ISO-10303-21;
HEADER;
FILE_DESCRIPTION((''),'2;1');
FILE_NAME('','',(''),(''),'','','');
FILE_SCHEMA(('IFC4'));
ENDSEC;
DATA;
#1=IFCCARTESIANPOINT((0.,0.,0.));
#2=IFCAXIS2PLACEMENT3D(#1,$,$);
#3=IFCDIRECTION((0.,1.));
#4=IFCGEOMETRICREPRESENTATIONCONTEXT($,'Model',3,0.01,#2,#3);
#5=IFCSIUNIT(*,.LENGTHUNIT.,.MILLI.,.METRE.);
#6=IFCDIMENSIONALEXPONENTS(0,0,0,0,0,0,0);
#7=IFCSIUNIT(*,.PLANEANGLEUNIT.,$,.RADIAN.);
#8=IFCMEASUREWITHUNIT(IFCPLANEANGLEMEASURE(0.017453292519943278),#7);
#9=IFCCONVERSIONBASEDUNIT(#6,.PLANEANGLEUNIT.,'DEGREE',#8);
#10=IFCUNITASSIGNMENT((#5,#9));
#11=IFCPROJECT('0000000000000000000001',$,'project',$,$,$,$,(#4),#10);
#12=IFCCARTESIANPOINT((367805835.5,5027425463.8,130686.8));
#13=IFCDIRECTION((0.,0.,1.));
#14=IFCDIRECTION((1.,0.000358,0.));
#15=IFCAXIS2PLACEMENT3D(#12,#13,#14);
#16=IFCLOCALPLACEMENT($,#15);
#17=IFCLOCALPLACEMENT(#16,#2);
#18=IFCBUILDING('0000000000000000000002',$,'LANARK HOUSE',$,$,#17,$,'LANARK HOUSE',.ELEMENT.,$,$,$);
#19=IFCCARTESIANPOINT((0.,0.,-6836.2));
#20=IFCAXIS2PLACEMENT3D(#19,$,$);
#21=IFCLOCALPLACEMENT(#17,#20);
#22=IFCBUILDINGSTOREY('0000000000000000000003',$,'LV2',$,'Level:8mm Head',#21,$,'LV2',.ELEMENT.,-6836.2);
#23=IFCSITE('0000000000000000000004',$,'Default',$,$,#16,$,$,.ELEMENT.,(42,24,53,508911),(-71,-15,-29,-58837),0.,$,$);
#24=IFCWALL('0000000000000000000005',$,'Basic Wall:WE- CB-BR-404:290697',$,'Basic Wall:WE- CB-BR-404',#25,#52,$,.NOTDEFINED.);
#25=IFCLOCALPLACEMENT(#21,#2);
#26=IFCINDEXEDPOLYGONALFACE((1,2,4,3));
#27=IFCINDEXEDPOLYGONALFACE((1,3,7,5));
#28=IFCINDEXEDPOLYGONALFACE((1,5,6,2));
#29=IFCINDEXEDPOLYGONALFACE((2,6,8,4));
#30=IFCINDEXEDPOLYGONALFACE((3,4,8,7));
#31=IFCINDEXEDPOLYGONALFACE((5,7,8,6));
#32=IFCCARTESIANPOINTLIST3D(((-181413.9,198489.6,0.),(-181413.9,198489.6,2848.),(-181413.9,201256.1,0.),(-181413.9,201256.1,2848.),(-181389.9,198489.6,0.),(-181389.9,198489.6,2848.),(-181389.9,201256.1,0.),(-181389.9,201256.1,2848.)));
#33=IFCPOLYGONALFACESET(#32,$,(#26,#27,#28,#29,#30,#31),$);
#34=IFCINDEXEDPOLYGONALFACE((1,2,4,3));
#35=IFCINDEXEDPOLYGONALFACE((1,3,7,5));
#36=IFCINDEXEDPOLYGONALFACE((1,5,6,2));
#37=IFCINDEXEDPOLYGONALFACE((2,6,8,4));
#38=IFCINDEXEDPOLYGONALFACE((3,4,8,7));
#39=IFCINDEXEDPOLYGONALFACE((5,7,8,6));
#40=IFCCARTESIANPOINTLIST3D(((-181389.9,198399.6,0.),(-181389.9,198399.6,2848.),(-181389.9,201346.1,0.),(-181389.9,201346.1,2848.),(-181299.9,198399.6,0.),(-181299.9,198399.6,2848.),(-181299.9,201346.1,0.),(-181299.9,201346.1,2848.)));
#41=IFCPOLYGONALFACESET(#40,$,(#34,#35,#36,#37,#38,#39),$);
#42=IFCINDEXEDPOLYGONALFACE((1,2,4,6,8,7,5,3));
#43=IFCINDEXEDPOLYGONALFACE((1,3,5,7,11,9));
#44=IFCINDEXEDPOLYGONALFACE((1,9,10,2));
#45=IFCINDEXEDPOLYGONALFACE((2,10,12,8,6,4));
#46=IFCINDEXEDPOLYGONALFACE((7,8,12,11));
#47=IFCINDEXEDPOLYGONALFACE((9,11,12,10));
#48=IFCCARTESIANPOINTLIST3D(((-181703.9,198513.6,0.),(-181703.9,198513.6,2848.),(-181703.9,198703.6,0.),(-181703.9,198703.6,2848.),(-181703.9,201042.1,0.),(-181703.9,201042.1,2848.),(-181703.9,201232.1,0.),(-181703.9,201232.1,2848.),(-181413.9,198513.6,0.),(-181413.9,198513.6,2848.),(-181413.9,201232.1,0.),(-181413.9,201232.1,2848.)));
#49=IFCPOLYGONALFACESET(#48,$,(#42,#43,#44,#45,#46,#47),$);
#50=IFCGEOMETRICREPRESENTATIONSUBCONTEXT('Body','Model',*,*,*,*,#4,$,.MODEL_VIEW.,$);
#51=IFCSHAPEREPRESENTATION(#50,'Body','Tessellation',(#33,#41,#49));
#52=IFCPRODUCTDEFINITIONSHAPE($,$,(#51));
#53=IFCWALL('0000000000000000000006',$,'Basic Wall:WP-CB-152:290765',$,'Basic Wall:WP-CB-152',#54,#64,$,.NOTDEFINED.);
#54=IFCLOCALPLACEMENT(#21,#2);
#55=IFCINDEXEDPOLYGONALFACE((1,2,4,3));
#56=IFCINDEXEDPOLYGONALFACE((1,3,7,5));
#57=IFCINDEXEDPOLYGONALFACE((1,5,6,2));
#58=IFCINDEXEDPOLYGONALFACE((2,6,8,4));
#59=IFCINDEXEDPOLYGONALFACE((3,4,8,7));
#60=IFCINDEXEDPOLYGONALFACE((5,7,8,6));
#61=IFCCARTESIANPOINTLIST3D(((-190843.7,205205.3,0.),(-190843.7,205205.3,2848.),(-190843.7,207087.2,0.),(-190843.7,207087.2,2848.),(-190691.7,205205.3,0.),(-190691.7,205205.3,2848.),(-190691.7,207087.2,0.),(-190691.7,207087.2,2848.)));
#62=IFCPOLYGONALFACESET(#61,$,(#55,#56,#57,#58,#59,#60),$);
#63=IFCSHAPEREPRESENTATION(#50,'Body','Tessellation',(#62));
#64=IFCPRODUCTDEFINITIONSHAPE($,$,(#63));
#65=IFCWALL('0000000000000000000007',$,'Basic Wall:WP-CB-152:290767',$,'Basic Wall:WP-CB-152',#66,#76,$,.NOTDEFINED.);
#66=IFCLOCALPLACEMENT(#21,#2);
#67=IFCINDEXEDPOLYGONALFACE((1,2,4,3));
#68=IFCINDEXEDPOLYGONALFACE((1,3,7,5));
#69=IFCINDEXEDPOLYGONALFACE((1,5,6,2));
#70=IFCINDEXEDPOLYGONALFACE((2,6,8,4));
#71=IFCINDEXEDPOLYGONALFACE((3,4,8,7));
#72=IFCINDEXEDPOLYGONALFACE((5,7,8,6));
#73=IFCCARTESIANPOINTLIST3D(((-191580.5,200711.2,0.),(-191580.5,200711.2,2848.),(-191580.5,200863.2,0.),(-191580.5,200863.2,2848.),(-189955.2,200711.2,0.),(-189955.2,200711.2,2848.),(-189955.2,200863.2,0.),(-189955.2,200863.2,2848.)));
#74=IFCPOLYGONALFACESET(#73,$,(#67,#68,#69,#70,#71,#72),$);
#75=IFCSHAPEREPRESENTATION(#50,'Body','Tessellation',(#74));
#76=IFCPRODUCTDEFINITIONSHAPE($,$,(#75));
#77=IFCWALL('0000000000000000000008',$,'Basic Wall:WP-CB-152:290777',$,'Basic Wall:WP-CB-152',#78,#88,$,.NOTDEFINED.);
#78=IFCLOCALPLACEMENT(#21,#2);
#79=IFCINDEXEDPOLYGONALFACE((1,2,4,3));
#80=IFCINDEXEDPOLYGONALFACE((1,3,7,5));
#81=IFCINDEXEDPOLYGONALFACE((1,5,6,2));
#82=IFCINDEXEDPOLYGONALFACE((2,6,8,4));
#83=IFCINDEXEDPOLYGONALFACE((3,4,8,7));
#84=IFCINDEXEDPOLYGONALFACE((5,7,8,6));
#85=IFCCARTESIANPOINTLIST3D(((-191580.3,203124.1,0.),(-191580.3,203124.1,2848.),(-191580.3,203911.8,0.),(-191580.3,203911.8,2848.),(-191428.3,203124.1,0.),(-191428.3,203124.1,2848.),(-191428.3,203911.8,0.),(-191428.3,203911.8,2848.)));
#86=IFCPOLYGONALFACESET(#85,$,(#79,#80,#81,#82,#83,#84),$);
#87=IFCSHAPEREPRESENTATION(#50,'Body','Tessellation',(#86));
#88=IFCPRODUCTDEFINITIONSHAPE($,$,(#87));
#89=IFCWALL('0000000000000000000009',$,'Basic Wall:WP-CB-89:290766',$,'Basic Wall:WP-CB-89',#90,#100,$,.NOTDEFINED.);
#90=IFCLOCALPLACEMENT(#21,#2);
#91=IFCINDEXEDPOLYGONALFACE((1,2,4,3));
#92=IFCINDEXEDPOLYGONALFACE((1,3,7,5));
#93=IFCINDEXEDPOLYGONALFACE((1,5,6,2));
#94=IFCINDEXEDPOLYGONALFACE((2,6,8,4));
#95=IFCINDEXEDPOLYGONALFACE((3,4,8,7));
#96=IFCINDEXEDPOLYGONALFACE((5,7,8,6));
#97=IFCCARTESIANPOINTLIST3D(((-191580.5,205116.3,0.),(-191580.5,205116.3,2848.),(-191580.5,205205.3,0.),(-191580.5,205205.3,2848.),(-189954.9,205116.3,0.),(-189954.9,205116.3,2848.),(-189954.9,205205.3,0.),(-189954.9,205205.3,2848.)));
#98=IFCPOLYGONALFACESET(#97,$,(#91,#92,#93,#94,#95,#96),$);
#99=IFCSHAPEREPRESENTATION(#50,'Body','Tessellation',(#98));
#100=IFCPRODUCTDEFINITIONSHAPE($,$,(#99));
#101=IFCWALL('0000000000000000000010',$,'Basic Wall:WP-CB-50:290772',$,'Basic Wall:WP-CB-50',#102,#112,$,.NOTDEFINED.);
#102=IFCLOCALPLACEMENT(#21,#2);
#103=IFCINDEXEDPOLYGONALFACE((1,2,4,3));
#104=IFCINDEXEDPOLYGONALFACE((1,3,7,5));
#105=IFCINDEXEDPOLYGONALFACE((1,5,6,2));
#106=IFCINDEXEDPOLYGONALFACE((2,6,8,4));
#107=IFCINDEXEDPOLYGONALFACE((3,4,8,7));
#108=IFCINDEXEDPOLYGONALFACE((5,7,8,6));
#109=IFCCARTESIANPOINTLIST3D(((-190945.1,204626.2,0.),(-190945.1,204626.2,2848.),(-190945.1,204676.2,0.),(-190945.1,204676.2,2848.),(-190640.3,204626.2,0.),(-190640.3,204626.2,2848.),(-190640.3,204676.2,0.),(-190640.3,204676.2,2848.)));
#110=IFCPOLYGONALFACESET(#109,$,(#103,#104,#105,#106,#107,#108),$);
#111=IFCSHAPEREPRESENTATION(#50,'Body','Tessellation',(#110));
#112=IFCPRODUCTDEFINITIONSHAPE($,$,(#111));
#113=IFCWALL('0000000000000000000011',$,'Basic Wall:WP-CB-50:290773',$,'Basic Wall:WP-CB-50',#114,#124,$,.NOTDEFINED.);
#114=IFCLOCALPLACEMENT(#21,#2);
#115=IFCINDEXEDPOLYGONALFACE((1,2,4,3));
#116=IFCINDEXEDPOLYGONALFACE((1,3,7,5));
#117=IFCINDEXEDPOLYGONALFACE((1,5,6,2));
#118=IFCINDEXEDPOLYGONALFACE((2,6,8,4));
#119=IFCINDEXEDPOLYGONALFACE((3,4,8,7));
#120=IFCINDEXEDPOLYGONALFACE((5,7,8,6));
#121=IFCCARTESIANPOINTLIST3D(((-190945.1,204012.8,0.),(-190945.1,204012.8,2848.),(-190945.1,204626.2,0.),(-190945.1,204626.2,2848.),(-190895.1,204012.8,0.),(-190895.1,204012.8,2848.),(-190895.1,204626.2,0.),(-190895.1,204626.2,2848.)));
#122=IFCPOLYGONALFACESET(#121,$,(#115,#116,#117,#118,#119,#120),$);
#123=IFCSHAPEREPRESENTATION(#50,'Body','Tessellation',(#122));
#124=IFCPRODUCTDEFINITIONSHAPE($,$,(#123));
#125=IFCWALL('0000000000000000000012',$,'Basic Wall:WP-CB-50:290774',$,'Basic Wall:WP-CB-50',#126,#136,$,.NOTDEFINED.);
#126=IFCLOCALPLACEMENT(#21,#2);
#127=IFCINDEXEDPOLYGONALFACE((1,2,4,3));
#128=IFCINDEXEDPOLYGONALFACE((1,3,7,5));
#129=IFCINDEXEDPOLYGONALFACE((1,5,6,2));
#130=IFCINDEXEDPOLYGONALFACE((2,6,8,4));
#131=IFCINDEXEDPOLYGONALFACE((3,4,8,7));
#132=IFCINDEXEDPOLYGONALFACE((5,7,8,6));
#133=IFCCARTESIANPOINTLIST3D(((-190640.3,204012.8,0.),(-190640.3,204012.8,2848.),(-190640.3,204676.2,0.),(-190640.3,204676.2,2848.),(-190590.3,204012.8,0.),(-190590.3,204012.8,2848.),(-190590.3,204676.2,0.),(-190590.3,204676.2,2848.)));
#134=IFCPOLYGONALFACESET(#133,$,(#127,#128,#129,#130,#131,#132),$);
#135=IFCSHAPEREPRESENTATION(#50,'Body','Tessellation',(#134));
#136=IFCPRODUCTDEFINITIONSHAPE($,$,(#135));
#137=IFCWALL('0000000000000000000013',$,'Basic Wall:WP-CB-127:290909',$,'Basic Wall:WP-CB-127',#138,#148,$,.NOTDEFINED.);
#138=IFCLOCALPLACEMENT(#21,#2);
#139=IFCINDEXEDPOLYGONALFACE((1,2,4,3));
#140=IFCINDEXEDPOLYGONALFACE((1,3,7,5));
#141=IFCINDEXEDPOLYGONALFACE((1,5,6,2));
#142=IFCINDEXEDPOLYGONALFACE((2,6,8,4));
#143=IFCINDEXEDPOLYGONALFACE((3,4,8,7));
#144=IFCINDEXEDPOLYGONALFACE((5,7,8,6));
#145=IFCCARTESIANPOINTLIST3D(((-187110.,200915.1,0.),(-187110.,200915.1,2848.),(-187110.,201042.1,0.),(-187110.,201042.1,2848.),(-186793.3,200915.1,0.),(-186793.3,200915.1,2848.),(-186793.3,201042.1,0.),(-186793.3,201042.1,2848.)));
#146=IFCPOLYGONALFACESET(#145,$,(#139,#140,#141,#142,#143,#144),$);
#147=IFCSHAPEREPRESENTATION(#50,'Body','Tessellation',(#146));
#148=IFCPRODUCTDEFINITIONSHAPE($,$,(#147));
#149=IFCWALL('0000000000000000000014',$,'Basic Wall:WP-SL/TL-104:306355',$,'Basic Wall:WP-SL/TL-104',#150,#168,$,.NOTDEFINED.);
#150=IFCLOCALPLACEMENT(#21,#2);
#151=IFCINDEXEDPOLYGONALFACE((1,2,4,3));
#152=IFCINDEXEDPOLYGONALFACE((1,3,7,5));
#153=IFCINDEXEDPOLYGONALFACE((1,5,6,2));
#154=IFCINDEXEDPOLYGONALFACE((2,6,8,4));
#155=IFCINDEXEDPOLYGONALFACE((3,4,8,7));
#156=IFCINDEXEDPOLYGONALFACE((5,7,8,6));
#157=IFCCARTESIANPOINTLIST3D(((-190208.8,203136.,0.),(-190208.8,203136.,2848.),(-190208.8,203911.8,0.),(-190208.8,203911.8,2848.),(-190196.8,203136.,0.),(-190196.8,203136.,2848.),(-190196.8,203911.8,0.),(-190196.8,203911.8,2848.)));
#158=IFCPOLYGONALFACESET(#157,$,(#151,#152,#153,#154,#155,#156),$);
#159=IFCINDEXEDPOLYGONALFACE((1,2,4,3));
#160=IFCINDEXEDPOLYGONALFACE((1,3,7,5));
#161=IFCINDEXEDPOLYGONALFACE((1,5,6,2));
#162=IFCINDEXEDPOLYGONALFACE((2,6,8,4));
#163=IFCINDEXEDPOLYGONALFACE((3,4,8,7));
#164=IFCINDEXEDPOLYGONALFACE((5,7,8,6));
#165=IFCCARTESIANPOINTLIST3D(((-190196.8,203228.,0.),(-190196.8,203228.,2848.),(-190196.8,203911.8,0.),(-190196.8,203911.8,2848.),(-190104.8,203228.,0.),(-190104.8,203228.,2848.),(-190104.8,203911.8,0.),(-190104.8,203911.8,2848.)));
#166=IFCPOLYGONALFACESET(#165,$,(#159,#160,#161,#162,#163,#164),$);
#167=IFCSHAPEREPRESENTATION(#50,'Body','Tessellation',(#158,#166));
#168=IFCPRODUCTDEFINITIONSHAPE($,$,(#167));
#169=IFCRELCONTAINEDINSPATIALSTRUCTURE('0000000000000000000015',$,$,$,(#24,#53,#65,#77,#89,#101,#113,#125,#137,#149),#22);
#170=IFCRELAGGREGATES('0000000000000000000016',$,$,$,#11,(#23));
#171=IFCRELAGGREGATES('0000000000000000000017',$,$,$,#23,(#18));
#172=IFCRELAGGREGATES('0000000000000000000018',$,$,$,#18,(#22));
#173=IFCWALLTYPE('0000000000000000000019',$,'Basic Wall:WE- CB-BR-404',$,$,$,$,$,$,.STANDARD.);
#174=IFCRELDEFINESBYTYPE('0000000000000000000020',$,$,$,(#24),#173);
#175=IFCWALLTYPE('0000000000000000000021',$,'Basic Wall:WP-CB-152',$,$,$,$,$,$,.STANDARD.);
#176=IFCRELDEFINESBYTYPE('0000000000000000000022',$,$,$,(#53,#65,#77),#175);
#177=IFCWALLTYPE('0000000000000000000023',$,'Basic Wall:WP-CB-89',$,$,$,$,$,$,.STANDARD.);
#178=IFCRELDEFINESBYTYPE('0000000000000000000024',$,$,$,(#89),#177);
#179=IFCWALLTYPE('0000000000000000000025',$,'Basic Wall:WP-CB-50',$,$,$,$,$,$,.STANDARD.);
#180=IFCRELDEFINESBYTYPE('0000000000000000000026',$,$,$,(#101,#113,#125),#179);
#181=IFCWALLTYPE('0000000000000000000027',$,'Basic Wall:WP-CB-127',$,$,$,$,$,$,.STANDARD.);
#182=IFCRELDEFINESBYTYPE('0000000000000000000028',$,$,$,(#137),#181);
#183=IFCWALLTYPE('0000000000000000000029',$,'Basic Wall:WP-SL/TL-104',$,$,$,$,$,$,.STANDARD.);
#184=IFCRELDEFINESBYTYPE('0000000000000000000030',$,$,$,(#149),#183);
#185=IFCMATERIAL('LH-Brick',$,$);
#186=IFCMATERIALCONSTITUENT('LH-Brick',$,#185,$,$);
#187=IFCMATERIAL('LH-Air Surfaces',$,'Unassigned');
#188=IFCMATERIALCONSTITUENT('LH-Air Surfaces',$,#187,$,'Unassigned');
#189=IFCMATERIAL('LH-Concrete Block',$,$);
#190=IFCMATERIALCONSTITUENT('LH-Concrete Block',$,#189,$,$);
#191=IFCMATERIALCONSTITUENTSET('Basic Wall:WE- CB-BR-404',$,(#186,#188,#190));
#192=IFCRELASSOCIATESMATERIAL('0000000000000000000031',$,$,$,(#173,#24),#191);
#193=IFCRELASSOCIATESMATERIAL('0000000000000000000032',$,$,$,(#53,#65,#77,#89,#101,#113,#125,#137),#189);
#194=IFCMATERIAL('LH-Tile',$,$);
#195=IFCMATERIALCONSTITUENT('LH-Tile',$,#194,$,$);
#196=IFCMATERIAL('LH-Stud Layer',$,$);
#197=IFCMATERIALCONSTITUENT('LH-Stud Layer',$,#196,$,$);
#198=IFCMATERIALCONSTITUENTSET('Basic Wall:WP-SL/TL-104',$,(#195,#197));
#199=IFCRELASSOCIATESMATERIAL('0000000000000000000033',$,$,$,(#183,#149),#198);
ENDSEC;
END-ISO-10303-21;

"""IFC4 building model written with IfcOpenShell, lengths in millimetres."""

from ifc_helpers import new_model, entity, si_unit, converted_unit, direction, frame, origin, place, context, subcontext, project, spatial, indexed_curve, outline, extrude, material, constituent, constituent_set, type_object, element, save


model = new_model("IFC4")

# Units and contexts
model_context = context("Model", 3, precision=0.01, world=origin(), true_north=direction((0.0, 1.0)))
body_context = subcontext(model_context, "Body", "Model", "MODEL_VIEW")
ifc_project = project(units=[si_unit("LENGTHUNIT", "METRE", prefix="MILLI"), converted_unit("PLANEANGLEUNIT", "DEGREE", entity("IfcPlaneAngleMeasure", 0.017453292519943278), si_unit("PLANEANGLEUNIT", "RADIAN"), dimensions=[0, 0, 0, 0, 0, 0, 0])], contexts=[model_context])

# Site, building, storey
site_placement = place(None, frame((367805835.5, 5027425463.8, 130686.8), z_axis=(0.0, 0.0, 1.0), x_axis=(1.0, 0.000358, 0.0)))
site = spatial("IfcSite", under=ifc_project, at=site_placement, Name="Default", CompositionType="ELEMENT", RefLatitude=(42, 24, 53, 508911), RefLongitude=(-71, -15, -29, -58837), RefElevation=0.0)
building_placement = place(site_placement, origin())
building = spatial("IfcBuilding", under=site, at=building_placement, Name="LANARK HOUSE", LongName="LANARK HOUSE", CompositionType="ELEMENT")
storey_placement = place(building_placement, frame((0.0, 0.0, -6836.2)))
storey = spatial("IfcBuildingStorey", under=building, at=storey_placement, Name="LV2", ObjectType="Level:8mm Head", LongName="LV2", CompositionType="ELEMENT", Elevation=-6836.2)

# Shared definitions
ifc_material_1 = material(Name="LH-Brick")
ifc_material_2 = material(Name="LH-Air Surfaces", Category="Unassigned")
ifc_material_3 = material(Name="LH-Concrete Block")

# Walls
ifc_constituent_1 = constituent(ifc_material_1, Name="LH-Brick")
ifc_constituent_2 = constituent(ifc_material_2, Name="LH-Air Surfaces", Category="Unassigned")
ifc_constituent_3 = constituent(ifc_material_3, Name="LH-Concrete Block")
ifc_constituent_set_1 = constituent_set(constituents=[ifc_constituent_1, ifc_constituent_2, ifc_constituent_3], Name="Basic Wall:WE- CB-BR-404")
wall_type_1 = type_object("IfcWallType", Name="Basic Wall:WE- CB-BR-404", PredefinedType="STANDARD", material=ifc_constituent_set_1)
wall_1_placement = place(storey_placement, frame((-181501.9, 201346.1, 0.0), z_axis=(0.0, 0.0, 1.0), x_axis=(0.0, -1.0, 0.0)))
element("IfcWall", 1, at=wall_1_placement, inside=storey, type_object=wall_type_1, material=ifc_constituent_set_1, Name="Basic Wall:WE- CB-BR-404:290697", ObjectType="Basic Wall:WE- CB-BR-404", PredefinedType="NOTDEFINED", context=body_context, shape_type="SweptSolid", body=[
    extrude(outline(indexed_curve([(-1383.2, -12.0), (1383.2, -12.0), (1383.2, 12.0), (-1383.2, 12.0), (-1383.2, -12.0)], self_intersect=False)), frame((1473.2, 100.0, 0.0)), (0.0, 0.0, 1.0), 2848.0),
    extrude(outline(indexed_curve([(-45.0, -1473.2), (45.0, -1473.2), (45.0, 1473.2), (-45.0, 1473.2), (-45.0, -1473.2)], self_intersect=False)), frame((1473.2, 157.0, 0.0), z_axis=(0.0, 0.0, 1.0), x_axis=(0.0, -1.0, 0.0)), (0.0, 0.0, 1.0), 2848.0),
    extrude(outline(indexed_curve([(-1169.2, -96.7), (1169.2, -96.7), (1359.2, -96.7), (1359.2, 193.3), (-1359.2, 193.3), (-1359.2, -96.7), (-1169.2, -96.7)], self_intersect=False)), frame((1473.2, -105.3, 0.0)), (0.0, 0.0, 1.0), 2848.0),
])
wall_type_2 = type_object("IfcWallType", Name="Basic Wall:WP-CB-152", PredefinedType="STANDARD")
wall_2_placement = place(storey_placement, frame((-190767.7, 205205.3, 0.0), z_axis=(0.0, 0.0, 1.0), x_axis=(0.0, 1.0, 0.0)))
element("IfcWall", 2, at=wall_2_placement, inside=storey, type_object=wall_type_2, material=ifc_material_3, Name="Basic Wall:WP-CB-152:290765", ObjectType="Basic Wall:WP-CB-152", PredefinedType="NOTDEFINED", context=body_context, shape_type="SweptSolid", body=[
    extrude(outline(indexed_curve([(1881.9, 76.0), (0.0, 76.0), (0.0, -76.0), (1881.9, -76.0), (1881.9, 76.0)], self_intersect=False)), origin(), (0.0, 0.0, 1.0), 2848.0),
])
wall_3_placement = place(storey_placement, frame((-189955.2, 200787.2, 0.0), z_axis=(0.0, 0.0, 1.0), x_axis=(-1.0, 0.0, 0.0)))
element("IfcWall", 3, at=wall_3_placement, inside=storey, type_object=wall_type_2, material=ifc_material_3, Name="Basic Wall:WP-CB-152:290767", ObjectType="Basic Wall:WP-CB-152", PredefinedType="NOTDEFINED", context=body_context, shape_type="SweptSolid", body=[
    extrude(outline(indexed_curve([(1625.3, 76.0), (0.0, 76.0), (0.0, -76.0), (1625.3, -76.0), (1625.3, 76.0)], self_intersect=False)), origin(), (0.0, 0.0, 1.0), 2848.0),
])
wall_4_placement = place(storey_placement, frame((-191504.3, 203124.1, 0.0), z_axis=(0.0, 0.0, 1.0), x_axis=(0.0, 1.0, 0.0)))
element("IfcWall", 4, at=wall_4_placement, inside=storey, type_object=wall_type_2, material=ifc_material_3, Name="Basic Wall:WP-CB-152:290777", ObjectType="Basic Wall:WP-CB-152", PredefinedType="NOTDEFINED", context=body_context, shape_type="SweptSolid", body=[
    extrude(outline(indexed_curve([(787.7, 76.0), (0.0, 76.0), (0.0, -76.0), (787.7, -76.0), (787.7, 76.0)], self_intersect=False)), origin(), (0.0, 0.0, 1.0), 2848.0),
])
wall_type_3 = type_object("IfcWallType", Name="Basic Wall:WP-CB-89", PredefinedType="STANDARD")
wall_5_placement = place(storey_placement, frame((-189954.9, 205160.8, 0.0), z_axis=(0.0, 0.0, 1.0), x_axis=(-1.0, 0.0, 0.0)))
element("IfcWall", 5, at=wall_5_placement, inside=storey, type_object=wall_type_3, material=ifc_material_3, Name="Basic Wall:WP-CB-89:290766", ObjectType="Basic Wall:WP-CB-89", PredefinedType="NOTDEFINED", context=body_context, shape_type="SweptSolid", body=[
    extrude(outline(indexed_curve([(1625.6, 44.5), (0.0, 44.5), (0.0, -44.5), (1625.6, -44.5), (1625.6, 44.5)], self_intersect=False)), origin(), (0.0, 0.0, 1.0), 2848.0),
])
wall_type_4 = type_object("IfcWallType", Name="Basic Wall:WP-CB-50", PredefinedType="STANDARD")
wall_6_placement = place(storey_placement, frame((-190945.1, 204651.2, 0.0)))
element("IfcWall", 6, at=wall_6_placement, inside=storey, type_object=wall_type_4, material=ifc_material_3, Name="Basic Wall:WP-CB-50:290772", ObjectType="Basic Wall:WP-CB-50", PredefinedType="NOTDEFINED", context=body_context, shape_type="SweptSolid", body=[
    extrude(outline(indexed_curve([(304.8, 25.0), (0.0, 25.0), (0.0, -25.0), (304.8, -25.0), (304.8, 25.0)], self_intersect=False)), origin(), (0.0, 0.0, 1.0), 2848.0),
])
wall_7_placement = place(storey_placement, frame((-190920.1, 204012.8, 0.0), z_axis=(0.0, 0.0, 1.0), x_axis=(0.0, 1.0, 0.0)))
element("IfcWall", 7, at=wall_7_placement, inside=storey, type_object=wall_type_4, material=ifc_material_3, Name="Basic Wall:WP-CB-50:290773", ObjectType="Basic Wall:WP-CB-50", PredefinedType="NOTDEFINED", context=body_context, shape_type="SweptSolid", body=[
    extrude(outline(indexed_curve([(613.5, 25.0), (0.0, 25.0), (0.0, -25.0), (613.5, -25.0), (613.5, 25.0)], self_intersect=False)), origin(), (0.0, 0.0, 1.0), 2848.0),
])
wall_8_placement = place(storey_placement, frame((-190615.3, 204012.8, 0.0), z_axis=(0.0, 0.0, 1.0), x_axis=(0.0, 1.0, 0.0)))
element("IfcWall", 8, at=wall_8_placement, inside=storey, type_object=wall_type_4, material=ifc_material_3, Name="Basic Wall:WP-CB-50:290774", ObjectType="Basic Wall:WP-CB-50", PredefinedType="NOTDEFINED", context=body_context, shape_type="SweptSolid", body=[
    extrude(outline(indexed_curve([(663.5, 25.0), (0.0, 25.0), (0.0, -25.0), (663.5, -25.0), (663.5, 25.0)], self_intersect=False)), origin(), (0.0, 0.0, 1.0), 2848.0),
])
wall_type_5 = type_object("IfcWallType", Name="Basic Wall:WP-CB-127", PredefinedType="STANDARD")
wall_9_placement = place(storey_placement, frame((-187110.0, 200978.6, 0.0)))
element("IfcWall", 9, at=wall_9_placement, inside=storey, type_object=wall_type_5, material=ifc_material_3, Name="Basic Wall:WP-CB-127:290909", ObjectType="Basic Wall:WP-CB-127", PredefinedType="NOTDEFINED", context=body_context, shape_type="SweptSolid", body=[
    extrude(outline(indexed_curve([(316.7, 63.5), (0.0, 63.5), (0.0, -63.5), (316.7, -63.5), (316.7, 63.5)], self_intersect=False)), origin(), (0.0, 0.0, 1.0), 2848.0),
])

# Shared definitions
ifc_material_4 = material(Name="LH-Stud Layer")

# Wall
ifc_material_5 = material(Name="LH-Tile")
ifc_constituent_4 = constituent(ifc_material_5, Name="LH-Tile")
ifc_constituent_5 = constituent(ifc_material_4, Name="LH-Stud Layer")
ifc_constituent_set_2 = constituent_set(constituents=[ifc_constituent_4, ifc_constituent_5], Name="Basic Wall:WP-SL/TL-104")
wall_type_6 = type_object("IfcWallType", Name="Basic Wall:WP-SL/TL-104", PredefinedType="STANDARD", material=ifc_constituent_set_2)
wall_10_placement = place(storey_placement, frame((-190156.8, 203228.0, 0.0), z_axis=(0.0, 0.0, 1.0), x_axis=(0.0, 1.0, 0.0)))
element("IfcWall", 10, at=wall_10_placement, inside=storey, type_object=wall_type_6, material=ifc_constituent_set_2, Name="Basic Wall:WP-SL/TL-104:306355", ObjectType="Basic Wall:WP-SL/TL-104", PredefinedType="NOTDEFINED", context=body_context, shape_type="SweptSolid", body=[
    extrude(outline(indexed_curve([(-6.0, -387.9), (6.0, -387.9), (6.0, 387.9), (-6.0, 387.9), (-6.0, -387.9)], self_intersect=False)), frame((295.9, 46.0, 0.0), z_axis=(0.0, 0.0, 1.0), x_axis=(0.0, -1.0, 0.0)), (0.0, 0.0, 1.0), 2848.0),
    extrude(outline(indexed_curve([(-46.0, -341.9), (46.0, -341.9), (46.0, 341.9), (-46.0, 341.9), (-46.0, -341.9)], self_intersect=False)), frame((341.9, -6.0, 0.0), z_axis=(0.0, 0.0, 1.0), x_axis=(0.0, 1.0, 0.0)), (0.0, 0.0, 1.0), 2848.0),
])

save(model, "model.ifc")
